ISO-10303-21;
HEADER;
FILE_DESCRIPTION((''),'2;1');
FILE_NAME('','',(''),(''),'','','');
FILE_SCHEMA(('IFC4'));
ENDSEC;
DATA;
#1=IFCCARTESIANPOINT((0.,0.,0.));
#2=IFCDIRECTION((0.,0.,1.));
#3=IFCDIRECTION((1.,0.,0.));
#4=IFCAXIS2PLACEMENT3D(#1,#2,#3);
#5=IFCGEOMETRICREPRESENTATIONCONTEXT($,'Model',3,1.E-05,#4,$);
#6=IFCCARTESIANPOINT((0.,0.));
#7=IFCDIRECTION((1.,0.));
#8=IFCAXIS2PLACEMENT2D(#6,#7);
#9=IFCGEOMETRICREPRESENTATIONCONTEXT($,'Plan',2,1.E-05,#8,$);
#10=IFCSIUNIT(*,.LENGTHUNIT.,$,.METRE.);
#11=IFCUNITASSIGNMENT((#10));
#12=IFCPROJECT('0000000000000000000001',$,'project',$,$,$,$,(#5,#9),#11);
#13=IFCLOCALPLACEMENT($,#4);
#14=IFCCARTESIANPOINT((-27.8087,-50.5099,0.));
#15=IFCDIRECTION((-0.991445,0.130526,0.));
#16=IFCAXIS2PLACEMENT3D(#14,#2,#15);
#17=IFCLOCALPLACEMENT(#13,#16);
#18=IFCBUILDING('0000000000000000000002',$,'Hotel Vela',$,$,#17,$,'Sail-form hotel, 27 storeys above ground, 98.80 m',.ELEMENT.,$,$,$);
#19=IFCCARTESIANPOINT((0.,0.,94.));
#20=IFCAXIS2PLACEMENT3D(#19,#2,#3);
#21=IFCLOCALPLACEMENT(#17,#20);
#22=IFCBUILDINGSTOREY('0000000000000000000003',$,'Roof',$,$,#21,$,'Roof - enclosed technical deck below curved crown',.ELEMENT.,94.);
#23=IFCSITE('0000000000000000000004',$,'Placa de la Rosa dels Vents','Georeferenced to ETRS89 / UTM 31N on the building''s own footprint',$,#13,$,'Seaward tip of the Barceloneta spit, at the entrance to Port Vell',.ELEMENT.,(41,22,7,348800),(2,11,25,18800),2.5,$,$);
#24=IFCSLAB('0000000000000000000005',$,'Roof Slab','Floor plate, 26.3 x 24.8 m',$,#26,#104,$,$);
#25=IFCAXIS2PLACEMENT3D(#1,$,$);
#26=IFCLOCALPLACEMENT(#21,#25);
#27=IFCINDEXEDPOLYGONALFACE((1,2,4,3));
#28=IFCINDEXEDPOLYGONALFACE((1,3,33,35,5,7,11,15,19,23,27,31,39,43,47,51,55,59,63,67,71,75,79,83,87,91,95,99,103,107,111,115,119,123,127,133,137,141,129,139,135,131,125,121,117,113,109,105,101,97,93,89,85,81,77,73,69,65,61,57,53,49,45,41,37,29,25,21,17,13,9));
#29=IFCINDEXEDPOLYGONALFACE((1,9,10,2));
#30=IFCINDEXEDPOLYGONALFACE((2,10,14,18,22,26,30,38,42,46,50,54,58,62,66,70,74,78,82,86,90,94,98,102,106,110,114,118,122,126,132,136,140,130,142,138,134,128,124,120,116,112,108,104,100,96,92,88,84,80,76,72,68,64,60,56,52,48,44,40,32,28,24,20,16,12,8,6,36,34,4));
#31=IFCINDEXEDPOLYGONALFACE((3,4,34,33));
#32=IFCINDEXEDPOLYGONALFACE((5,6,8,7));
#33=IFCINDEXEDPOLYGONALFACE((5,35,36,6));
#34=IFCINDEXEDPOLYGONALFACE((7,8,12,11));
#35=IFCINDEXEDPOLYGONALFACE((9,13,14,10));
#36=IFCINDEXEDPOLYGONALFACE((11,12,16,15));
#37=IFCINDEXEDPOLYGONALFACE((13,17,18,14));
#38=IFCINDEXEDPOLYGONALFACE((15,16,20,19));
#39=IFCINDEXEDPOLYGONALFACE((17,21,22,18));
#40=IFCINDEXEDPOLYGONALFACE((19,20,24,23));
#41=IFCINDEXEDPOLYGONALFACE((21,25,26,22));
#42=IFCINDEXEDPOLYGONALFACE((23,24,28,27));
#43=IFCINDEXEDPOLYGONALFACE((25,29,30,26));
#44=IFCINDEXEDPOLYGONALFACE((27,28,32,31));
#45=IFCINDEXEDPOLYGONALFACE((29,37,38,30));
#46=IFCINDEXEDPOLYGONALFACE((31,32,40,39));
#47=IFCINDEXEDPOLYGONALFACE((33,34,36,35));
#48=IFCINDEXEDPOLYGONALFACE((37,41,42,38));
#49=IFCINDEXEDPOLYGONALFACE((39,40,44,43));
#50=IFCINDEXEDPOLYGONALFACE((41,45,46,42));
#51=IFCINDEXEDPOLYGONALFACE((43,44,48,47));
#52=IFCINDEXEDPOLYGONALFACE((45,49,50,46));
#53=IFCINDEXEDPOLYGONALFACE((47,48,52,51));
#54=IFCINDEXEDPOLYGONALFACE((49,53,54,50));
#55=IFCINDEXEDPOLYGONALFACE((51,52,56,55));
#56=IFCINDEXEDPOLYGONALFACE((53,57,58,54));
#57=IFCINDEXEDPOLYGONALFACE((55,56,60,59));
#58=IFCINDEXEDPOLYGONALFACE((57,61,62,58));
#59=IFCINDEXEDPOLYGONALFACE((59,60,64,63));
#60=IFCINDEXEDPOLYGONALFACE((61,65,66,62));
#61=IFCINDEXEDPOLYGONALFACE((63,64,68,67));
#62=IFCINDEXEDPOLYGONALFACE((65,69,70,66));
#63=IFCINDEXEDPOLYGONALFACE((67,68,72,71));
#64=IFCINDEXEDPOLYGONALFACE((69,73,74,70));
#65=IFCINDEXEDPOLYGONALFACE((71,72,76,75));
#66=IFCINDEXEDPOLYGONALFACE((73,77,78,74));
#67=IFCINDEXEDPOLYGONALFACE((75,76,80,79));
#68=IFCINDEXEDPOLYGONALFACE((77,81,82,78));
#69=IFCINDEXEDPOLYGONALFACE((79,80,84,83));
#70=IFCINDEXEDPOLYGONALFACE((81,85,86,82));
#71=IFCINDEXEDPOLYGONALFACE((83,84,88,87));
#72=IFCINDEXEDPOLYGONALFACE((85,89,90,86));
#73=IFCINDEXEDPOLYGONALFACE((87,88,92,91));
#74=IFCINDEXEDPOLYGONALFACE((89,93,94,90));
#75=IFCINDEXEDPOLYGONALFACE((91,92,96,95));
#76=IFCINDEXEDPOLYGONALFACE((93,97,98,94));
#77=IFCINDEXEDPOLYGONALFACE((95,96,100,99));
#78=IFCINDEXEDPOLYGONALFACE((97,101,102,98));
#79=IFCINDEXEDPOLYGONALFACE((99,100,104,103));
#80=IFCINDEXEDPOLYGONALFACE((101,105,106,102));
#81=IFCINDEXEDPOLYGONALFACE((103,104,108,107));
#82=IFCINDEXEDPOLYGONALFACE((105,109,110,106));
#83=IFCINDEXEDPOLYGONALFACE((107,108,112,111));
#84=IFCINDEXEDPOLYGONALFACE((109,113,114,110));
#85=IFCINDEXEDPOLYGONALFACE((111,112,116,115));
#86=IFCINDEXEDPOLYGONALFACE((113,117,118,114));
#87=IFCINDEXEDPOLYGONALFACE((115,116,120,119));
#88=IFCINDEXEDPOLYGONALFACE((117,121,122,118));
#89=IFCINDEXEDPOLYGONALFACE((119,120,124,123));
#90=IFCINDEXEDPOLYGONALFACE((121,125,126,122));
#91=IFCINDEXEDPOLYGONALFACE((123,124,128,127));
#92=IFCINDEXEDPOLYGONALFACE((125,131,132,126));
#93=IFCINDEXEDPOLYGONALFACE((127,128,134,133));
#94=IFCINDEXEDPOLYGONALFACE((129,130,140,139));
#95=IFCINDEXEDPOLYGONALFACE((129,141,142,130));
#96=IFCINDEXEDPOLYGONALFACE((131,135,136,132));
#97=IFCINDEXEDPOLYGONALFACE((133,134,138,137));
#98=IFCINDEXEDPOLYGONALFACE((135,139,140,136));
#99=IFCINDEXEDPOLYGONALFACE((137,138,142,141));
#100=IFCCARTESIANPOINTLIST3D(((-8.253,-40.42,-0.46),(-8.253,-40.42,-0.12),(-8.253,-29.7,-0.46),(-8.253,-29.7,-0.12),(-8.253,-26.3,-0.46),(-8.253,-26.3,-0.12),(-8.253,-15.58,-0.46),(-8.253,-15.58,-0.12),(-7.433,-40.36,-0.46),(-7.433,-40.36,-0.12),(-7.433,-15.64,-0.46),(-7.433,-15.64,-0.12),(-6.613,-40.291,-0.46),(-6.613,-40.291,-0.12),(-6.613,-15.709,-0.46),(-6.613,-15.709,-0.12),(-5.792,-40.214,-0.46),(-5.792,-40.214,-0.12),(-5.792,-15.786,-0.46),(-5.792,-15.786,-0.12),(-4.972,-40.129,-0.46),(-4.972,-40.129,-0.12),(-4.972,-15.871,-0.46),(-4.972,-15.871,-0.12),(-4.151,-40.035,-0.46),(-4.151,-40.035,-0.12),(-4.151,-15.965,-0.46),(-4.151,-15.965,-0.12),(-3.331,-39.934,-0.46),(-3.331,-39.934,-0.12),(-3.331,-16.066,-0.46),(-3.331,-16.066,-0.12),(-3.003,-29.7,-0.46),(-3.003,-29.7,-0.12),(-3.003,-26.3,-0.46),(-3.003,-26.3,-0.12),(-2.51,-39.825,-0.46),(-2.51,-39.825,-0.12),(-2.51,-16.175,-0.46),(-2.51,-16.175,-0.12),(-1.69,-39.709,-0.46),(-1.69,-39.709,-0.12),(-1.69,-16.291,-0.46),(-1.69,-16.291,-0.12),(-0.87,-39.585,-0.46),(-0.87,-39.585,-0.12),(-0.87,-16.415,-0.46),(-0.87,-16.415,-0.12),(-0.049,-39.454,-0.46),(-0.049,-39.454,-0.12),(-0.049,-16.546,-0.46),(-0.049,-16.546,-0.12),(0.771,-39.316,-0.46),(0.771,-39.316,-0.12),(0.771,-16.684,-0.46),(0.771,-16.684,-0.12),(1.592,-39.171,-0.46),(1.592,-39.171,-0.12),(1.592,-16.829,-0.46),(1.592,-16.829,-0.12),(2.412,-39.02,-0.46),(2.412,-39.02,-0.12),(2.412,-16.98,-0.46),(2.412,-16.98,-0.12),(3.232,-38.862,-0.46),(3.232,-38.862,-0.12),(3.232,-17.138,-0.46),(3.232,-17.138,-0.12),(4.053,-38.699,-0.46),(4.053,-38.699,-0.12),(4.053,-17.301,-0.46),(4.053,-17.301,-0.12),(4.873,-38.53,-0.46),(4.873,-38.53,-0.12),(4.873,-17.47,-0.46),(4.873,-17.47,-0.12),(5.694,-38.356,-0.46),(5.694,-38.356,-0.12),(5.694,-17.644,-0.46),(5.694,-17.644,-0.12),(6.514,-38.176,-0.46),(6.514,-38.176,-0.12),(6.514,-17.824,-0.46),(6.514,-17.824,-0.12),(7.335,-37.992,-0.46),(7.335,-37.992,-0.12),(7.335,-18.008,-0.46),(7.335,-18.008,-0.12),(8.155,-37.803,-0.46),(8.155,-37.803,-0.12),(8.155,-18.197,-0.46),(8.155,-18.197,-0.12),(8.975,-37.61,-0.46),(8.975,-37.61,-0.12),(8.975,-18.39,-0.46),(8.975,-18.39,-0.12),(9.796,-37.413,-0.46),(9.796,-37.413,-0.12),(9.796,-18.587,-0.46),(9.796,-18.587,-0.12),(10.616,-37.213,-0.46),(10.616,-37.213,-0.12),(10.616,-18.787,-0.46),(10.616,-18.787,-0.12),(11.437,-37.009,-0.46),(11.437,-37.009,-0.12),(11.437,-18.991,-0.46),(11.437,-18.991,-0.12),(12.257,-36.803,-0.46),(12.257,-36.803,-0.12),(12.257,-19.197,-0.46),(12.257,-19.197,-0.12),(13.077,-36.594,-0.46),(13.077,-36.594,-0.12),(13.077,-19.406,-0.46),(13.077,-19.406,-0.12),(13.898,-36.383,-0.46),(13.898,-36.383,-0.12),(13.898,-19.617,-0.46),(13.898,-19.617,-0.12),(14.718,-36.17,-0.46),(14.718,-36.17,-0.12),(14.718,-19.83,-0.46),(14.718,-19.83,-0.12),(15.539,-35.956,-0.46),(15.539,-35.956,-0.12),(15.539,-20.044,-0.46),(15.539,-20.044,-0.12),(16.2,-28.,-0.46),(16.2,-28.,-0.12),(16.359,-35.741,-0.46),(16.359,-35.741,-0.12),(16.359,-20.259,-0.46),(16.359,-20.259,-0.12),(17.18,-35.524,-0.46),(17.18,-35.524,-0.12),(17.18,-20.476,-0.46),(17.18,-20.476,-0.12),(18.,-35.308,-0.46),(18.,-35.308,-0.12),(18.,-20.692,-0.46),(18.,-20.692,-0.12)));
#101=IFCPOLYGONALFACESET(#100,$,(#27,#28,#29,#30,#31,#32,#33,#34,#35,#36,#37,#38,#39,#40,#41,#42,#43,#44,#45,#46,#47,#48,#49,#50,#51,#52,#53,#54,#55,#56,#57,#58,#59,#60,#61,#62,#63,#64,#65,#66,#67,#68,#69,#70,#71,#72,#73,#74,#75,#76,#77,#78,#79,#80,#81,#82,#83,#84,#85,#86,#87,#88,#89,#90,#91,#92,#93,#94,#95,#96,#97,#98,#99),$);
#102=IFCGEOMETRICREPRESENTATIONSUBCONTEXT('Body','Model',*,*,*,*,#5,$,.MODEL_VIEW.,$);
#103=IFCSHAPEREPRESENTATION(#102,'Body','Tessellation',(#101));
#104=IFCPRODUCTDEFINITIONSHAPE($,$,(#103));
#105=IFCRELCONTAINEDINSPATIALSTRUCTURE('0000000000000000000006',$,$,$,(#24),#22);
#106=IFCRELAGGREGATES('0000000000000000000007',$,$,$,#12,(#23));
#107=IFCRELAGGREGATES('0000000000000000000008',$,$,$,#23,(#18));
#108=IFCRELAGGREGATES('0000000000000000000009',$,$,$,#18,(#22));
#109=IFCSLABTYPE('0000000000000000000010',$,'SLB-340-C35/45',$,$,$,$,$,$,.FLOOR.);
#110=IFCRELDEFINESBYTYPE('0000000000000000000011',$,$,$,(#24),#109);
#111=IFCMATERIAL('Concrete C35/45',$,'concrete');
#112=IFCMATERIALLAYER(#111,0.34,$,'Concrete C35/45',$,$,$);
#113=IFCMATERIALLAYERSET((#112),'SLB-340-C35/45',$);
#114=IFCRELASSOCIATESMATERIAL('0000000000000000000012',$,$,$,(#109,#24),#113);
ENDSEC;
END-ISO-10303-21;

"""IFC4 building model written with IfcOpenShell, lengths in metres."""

from ifc_helpers import new_model, si_unit, frame, origin_with_axes, origin_2d_with_axis, place, context, subcontext, project, spatial, line, indexed_curve, outline, extrude, material, layer, layer_set, layer_usage, type_object, element, save


model = new_model("IFC4")

# Units and contexts
model_context = context("Model", 3, precision=1e-05, world=origin_with_axes())
plan_context = context("Plan", 2, precision=1e-05, world=origin_2d_with_axis())
body_context = subcontext(model_context, "Body", "Model", "MODEL_VIEW")
ifc_project = project(units=[si_unit("LENGTHUNIT", "METRE")], contexts=[model_context, plan_context])

# Site, building, storey
site_placement = place(None, origin_with_axes())
site = spatial("IfcSite", under=ifc_project, at=site_placement, Name="Placa de la Rosa dels Vents", Description="Georeferenced to ETRS89 / UTM 31N on the building's own footprint", LongName="Seaward tip of the Barceloneta spit, at the entrance to Port Vell", CompositionType="ELEMENT", RefLatitude=(41, 22, 7, 348800), RefLongitude=(2, 11, 25, 18800), RefElevation=2.5)
building_placement = place(site_placement, frame((-27.8087, -50.5099, 0.0), z_axis=(0.0, 0.0, 1.0), x_axis=(-0.991445, 0.130526, 0.0)))
building = spatial("IfcBuilding", under=site, at=building_placement, Name="Hotel Vela", LongName="Sail-form hotel, 27 storeys above ground, 98.80 m", CompositionType="ELEMENT")
storey_placement = place(building_placement, frame((0.0, 0.0, 94.0), z_axis=(0.0, 0.0, 1.0), x_axis=(1.0, 0.0, 0.0)))
storey = spatial("IfcBuildingStorey", under=building, at=storey_placement, Name="Roof", LongName="Roof - enclosed technical deck below curved crown", CompositionType="ELEMENT", Elevation=94.0)

# Slab
ifc_material = material(Name="Concrete C35/45", Category="concrete")
ifc_layer = layer(ifc_material, 0.34, Name="Concrete C35/45")
ifc_layer_set = layer_set([ifc_layer], Name="SLB-340-C35/45")
ifc_layer_usage = layer_usage(ifc_layer_set, "AXIS3", "POSITIVE", 0.0)
slab_type = type_object("IfcSlabType", Name="SLB-340-C35/45", PredefinedType="FLOOR", material=ifc_layer_set)
slab_placement = place(storey_placement, frame((0.0, 0.0, -0.46), z_axis=(0.0, 0.0, 1.0), x_axis=(1.0, 0.0, 0.0)))
element("IfcSlab", 1, at=slab_placement, inside=storey, type_object=slab_type, material=ifc_layer_usage, Name="Roof Slab", Description="Floor plate, 26.3 x 24.8 m", context=body_context, shape_type="SweptSolid", body=[
    extrude(outline(indexed_curve([(-8.253, -40.42), (-7.433, -40.36), (-6.613, -40.291), (-5.792, -40.214), (-4.972, -40.129), (-4.151, -40.035), (-3.331, -39.934), (-2.51, -39.825), (-1.69, -39.709), (-0.87, -39.585), (-0.049, -39.454), (0.771, -39.316), (1.592, -39.171), (2.412, -39.02), (3.232, -38.862), (4.053, -38.699), (4.873, -38.53), (5.694, -38.356), (6.514, -38.176), (7.335, -37.992), (8.155, -37.803), (8.975, -37.61), (9.796, -37.413), (10.616, -37.213), (11.437, -37.009), (12.257, -36.803), (13.077, -36.594), (13.898, -36.383), (14.718, -36.17), (15.539, -35.956), (16.359, -35.741), (17.18, -35.524), (18.0, -35.308), (16.2, -28.0), (18.0, -20.692), (17.18, -20.476), (16.359, -20.259), (15.539, -20.044), (14.718, -19.83), (13.898, -19.617), (13.077, -19.406), (12.257, -19.197), (11.437, -18.991), (10.616, -18.787), (9.796, -18.587), (8.975, -18.39), (8.155, -18.197), (7.335, -18.008), (6.514, -17.824), (5.694, -17.644), (4.873, -17.47), (4.053, -17.301), (3.232, -17.138), (2.412, -16.98), (1.592, -16.829), (0.771, -16.684), (-0.049, -16.546), (-0.87, -16.415), (-1.69, -16.291), (-2.51, -16.175), (-3.331, -16.066), (-4.151, -15.965), (-4.972, -15.871), (-5.792, -15.786), (-6.613, -15.709), (-7.433, -15.64), (-8.253, -15.58), (-8.253, -26.3), (-3.003, -26.3), (-3.003, -29.7), (-8.253, -29.7)], segments=[line(1, 2, 3, 4, 5, 6, 7, 8, 9, 10, 11, 12, 13, 14, 15, 16, 17, 18, 19, 20, 21, 22, 23, 24, 25, 26, 27, 28, 29, 30, 31, 32, 33, 34, 35, 36, 37, 38, 39, 40, 41, 42, 43, 44, 45, 46, 47, 48, 49, 50, 51, 52, 53, 54, 55, 56, 57, 58, 59, 60, 61, 62, 63, 64, 65, 66, 67, 68, 69, 70, 71, 1)])), origin_with_axes(), (0.0, 0.0, 1.0), 0.34),
])

save(model, "model.ifc")
